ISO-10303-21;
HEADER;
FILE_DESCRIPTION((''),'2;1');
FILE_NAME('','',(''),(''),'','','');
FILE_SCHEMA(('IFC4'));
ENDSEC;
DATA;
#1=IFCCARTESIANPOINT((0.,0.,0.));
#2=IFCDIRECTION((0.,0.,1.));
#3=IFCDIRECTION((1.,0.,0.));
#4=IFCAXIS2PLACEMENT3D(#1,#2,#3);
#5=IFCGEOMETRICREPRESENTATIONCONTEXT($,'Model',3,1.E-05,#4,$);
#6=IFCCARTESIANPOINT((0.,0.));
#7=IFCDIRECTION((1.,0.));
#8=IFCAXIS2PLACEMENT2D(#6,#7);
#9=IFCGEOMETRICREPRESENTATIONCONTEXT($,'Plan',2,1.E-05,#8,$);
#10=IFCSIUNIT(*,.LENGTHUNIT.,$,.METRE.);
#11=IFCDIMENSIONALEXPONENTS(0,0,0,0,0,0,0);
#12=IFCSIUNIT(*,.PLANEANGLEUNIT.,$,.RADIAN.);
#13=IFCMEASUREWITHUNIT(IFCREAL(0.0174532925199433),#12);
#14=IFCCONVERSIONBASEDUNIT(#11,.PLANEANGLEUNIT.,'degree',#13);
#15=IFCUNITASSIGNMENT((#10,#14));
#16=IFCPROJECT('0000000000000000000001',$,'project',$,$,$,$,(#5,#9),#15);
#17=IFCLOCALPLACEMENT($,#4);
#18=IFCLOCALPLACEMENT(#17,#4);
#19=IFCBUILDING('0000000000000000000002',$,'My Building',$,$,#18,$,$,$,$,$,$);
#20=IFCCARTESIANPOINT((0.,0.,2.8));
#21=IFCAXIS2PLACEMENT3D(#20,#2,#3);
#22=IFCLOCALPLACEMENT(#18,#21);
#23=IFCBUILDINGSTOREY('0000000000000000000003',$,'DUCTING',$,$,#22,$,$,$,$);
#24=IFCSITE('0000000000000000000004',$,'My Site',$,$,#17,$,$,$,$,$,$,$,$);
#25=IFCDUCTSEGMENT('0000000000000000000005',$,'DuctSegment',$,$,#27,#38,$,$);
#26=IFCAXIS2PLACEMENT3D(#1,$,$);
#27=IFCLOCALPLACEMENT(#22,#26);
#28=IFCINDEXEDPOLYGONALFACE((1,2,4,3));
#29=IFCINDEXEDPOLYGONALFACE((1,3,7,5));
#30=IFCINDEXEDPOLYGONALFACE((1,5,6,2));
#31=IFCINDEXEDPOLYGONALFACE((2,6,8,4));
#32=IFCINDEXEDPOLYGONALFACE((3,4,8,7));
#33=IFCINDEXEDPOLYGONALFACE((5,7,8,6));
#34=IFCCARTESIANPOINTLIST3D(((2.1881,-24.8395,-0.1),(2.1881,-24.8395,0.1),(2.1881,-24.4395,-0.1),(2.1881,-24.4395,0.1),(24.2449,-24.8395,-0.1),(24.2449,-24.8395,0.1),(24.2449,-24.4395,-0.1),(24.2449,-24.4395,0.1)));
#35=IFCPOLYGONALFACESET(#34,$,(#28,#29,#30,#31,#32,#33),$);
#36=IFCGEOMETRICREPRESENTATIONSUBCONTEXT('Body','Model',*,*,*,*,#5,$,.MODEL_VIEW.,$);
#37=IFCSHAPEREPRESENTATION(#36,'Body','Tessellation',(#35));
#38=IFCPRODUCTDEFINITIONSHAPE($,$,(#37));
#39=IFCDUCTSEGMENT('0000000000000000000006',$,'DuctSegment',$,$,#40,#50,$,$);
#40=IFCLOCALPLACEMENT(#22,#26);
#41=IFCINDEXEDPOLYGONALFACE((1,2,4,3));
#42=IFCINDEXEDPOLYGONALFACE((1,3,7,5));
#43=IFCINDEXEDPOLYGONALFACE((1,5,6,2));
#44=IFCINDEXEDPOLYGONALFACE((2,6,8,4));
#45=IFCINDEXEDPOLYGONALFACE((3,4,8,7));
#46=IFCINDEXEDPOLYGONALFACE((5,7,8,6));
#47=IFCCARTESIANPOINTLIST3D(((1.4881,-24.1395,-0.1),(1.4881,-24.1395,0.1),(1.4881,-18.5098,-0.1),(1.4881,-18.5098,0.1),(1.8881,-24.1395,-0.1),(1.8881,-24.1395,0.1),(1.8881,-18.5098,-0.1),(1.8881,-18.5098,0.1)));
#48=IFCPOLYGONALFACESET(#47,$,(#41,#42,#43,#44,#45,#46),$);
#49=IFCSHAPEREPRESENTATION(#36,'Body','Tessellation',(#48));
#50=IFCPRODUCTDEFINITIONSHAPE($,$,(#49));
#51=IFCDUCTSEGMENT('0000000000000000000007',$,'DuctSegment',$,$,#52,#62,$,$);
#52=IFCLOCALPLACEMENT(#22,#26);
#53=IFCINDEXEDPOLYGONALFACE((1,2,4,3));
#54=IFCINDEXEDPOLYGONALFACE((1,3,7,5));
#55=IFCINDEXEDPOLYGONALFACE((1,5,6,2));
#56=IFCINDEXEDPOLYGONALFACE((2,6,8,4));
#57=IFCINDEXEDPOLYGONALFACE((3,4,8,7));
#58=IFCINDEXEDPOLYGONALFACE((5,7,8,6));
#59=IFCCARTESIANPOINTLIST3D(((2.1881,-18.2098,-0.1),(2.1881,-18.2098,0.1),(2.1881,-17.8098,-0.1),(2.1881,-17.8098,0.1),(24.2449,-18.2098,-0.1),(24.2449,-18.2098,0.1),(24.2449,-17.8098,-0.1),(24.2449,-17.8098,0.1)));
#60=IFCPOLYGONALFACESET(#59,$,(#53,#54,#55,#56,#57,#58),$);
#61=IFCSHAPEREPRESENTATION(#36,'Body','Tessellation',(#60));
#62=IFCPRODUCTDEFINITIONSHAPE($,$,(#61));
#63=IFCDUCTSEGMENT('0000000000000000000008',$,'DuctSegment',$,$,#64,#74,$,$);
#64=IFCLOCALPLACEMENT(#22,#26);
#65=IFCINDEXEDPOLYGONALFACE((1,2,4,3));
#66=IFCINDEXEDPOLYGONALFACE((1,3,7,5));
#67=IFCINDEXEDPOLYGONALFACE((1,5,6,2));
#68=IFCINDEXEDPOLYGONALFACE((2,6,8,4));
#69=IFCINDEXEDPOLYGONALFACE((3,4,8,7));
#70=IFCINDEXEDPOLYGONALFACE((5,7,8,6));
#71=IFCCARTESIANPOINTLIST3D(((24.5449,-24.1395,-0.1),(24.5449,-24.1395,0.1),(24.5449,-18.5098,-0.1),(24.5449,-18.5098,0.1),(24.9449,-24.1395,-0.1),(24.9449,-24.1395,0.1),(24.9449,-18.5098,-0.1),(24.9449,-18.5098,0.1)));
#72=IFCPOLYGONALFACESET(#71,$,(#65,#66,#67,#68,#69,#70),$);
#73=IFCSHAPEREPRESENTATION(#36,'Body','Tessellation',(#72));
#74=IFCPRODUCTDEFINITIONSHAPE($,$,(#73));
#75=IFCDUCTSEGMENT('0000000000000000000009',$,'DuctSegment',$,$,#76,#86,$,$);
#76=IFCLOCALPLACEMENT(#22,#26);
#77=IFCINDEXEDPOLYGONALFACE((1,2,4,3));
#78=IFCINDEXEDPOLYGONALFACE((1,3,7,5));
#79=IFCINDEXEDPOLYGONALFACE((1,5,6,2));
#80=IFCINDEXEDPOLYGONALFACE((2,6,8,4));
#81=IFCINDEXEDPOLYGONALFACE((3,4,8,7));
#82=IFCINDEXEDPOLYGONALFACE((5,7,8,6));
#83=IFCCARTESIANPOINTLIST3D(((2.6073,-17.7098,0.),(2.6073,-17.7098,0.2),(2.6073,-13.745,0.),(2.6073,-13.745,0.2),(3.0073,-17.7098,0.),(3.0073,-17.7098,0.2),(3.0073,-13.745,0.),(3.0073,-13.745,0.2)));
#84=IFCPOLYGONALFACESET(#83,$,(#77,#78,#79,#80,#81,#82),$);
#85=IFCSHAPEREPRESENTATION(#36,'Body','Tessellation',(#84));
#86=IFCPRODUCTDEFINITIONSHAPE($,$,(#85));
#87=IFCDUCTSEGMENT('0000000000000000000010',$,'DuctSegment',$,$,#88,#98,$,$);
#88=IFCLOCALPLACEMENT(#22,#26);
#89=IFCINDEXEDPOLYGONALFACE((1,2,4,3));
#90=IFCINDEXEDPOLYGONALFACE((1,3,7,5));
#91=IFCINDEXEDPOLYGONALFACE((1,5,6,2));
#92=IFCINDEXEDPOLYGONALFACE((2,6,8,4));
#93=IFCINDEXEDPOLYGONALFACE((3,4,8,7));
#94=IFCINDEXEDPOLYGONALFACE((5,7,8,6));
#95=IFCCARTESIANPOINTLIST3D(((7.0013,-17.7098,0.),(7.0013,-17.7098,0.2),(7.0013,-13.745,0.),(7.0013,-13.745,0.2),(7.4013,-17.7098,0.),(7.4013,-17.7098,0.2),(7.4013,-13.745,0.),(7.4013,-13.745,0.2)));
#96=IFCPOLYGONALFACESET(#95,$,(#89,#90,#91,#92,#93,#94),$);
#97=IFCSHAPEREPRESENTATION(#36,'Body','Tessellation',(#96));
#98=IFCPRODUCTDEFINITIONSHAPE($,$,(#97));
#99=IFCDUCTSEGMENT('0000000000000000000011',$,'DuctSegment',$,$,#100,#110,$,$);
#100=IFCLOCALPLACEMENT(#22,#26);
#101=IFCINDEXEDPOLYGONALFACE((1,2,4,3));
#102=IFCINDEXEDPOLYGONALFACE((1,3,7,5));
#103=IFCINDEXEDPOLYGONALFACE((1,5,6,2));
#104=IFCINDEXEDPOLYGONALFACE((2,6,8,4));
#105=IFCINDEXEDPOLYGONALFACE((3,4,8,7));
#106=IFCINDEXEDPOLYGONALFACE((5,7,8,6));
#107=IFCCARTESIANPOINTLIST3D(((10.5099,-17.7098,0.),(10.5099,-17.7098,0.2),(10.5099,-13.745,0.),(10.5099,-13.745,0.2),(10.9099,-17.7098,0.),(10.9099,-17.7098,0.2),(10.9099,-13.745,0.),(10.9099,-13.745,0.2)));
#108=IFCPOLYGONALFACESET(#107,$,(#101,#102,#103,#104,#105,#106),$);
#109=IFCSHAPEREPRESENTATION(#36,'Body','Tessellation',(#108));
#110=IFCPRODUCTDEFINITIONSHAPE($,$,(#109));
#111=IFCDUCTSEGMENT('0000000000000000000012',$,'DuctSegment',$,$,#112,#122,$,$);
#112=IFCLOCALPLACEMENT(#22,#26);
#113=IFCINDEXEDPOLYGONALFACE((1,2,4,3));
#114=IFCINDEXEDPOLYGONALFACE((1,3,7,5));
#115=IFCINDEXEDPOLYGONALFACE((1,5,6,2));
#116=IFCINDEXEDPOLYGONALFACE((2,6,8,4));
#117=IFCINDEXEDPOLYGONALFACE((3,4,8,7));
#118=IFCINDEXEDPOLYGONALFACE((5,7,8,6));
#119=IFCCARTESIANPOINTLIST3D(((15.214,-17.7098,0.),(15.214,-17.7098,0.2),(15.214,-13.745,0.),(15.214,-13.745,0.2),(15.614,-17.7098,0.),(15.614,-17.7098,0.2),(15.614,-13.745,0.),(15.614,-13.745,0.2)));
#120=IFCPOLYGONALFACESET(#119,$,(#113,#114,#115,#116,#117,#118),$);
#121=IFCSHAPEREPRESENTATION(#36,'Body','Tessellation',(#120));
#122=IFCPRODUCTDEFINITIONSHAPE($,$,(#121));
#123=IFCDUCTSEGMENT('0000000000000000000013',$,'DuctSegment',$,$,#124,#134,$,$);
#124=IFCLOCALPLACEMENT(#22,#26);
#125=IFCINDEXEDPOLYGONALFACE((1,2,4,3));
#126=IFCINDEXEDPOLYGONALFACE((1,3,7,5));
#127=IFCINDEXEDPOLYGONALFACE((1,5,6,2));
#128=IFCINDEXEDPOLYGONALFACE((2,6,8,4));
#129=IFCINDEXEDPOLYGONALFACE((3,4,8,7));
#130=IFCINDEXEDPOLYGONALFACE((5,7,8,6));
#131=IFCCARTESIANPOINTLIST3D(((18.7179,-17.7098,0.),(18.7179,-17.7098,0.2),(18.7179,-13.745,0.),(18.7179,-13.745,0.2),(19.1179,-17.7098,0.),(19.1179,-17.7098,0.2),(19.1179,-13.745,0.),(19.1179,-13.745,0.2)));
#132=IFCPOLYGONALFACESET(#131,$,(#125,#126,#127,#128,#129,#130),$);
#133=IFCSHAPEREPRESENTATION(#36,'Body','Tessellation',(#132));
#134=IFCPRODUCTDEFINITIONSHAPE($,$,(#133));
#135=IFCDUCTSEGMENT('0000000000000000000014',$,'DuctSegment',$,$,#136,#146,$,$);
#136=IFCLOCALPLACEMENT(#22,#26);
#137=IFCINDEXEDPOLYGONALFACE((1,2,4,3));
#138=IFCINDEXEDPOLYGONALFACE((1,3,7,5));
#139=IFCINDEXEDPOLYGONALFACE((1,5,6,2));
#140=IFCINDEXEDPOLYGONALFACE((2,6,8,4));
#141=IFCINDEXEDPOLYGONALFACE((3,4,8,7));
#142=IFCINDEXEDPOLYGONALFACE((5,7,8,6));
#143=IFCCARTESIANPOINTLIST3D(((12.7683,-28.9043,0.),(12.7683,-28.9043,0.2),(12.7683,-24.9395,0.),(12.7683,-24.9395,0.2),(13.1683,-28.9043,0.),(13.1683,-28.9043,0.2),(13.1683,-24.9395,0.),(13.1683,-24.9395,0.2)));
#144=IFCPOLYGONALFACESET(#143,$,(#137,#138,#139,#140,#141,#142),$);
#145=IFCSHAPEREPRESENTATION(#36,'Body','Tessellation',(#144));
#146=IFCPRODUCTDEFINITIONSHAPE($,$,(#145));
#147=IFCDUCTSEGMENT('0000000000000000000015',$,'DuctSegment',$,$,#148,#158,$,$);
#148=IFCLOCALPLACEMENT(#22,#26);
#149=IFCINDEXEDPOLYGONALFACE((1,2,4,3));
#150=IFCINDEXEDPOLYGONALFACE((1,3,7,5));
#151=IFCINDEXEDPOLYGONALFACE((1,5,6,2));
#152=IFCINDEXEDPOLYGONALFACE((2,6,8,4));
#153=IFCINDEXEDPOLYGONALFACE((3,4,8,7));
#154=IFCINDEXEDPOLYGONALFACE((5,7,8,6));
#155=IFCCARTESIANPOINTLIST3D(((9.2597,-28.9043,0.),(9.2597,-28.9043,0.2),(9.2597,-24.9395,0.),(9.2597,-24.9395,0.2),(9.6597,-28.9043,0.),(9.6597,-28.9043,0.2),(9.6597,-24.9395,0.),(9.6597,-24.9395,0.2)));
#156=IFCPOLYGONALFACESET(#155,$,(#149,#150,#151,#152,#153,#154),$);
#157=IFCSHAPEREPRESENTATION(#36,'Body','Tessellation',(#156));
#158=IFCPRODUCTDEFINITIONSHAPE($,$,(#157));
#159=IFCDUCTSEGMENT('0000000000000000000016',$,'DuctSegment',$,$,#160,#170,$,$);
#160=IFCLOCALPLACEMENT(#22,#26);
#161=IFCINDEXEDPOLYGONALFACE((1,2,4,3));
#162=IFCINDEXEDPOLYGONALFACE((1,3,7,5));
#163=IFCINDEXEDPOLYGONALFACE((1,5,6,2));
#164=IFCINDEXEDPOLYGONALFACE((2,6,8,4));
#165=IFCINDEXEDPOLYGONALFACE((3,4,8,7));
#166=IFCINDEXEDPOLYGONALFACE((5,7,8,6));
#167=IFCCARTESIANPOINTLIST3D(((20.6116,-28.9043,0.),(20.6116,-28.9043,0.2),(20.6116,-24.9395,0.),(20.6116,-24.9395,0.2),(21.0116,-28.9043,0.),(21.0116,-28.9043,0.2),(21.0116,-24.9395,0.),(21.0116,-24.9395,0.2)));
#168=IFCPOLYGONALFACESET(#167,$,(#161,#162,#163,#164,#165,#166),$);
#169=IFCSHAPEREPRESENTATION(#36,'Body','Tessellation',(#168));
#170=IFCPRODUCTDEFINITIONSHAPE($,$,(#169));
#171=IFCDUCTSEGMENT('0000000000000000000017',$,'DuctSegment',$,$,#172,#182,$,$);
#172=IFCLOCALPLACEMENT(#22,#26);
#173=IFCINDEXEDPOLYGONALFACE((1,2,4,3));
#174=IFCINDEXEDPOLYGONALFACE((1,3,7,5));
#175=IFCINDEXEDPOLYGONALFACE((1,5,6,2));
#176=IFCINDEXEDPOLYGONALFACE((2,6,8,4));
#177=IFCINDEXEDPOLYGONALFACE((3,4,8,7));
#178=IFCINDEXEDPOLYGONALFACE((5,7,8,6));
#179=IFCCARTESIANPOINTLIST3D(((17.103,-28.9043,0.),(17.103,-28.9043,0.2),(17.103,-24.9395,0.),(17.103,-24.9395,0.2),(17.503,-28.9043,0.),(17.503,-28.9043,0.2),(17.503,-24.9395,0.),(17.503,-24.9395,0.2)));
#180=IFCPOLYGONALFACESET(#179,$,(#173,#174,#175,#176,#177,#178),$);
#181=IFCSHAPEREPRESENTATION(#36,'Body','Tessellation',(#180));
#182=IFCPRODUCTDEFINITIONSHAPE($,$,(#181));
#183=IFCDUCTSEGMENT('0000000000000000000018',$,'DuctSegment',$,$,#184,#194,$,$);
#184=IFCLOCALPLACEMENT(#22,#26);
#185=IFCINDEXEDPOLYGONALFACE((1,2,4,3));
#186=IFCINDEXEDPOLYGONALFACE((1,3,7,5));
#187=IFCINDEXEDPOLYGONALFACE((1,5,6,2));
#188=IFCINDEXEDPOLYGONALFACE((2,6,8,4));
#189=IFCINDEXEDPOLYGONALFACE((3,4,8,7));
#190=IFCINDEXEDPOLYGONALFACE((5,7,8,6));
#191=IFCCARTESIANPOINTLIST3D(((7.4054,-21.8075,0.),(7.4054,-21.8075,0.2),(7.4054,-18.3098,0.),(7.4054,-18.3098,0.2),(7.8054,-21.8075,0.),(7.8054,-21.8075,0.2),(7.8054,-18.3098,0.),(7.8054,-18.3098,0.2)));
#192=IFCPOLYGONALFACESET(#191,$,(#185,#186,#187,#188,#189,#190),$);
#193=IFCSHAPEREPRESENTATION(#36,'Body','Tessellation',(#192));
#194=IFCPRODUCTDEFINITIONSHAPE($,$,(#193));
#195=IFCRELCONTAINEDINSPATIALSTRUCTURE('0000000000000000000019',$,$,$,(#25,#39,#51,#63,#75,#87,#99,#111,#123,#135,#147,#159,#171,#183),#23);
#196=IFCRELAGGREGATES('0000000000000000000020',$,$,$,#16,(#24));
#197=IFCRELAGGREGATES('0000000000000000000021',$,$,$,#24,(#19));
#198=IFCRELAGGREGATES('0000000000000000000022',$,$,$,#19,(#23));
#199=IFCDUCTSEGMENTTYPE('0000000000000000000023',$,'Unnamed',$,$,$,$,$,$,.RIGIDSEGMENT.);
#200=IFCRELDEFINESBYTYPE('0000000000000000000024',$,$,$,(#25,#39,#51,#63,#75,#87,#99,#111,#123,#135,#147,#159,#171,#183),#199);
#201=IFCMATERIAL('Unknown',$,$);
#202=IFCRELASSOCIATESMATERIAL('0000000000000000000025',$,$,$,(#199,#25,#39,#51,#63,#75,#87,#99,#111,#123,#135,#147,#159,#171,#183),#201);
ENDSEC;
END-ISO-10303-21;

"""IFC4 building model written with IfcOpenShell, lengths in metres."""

from ifc_helpers import new_model, entity, si_unit, converted_unit, frame, origin_with_axes, origin_2d_with_axis, place, context, subcontext, project, spatial, rectangle, extrude, material, material_profile, profile_set, profile_usage, type_object, element, save


model = new_model("IFC4")

# Units and contexts
model_context = context("Model", 3, precision=1e-05, world=origin_with_axes())
plan_context = context("Plan", 2, precision=1e-05, world=origin_2d_with_axis())
body_context = subcontext(model_context, "Body", "Model", "MODEL_VIEW")
ifc_project = project(units=[si_unit("LENGTHUNIT", "METRE"), converted_unit("PLANEANGLEUNIT", "degree", entity("IfcReal", 0.0174532925199433), si_unit("PLANEANGLEUNIT", "RADIAN"), dimensions=[0, 0, 0, 0, 0, 0, 0])], contexts=[model_context, plan_context])

# Site, building, storey
site_placement = place(None, origin_with_axes())
site = spatial("IfcSite", under=ifc_project, at=site_placement, Name="My Site")
building_placement = place(site_placement, origin_with_axes())
building = spatial("IfcBuilding", under=site, at=building_placement, Name="My Building")
storey_placement = place(building_placement, frame((0.0, 0.0, 2.8), z_axis=(0.0, 0.0, 1.0), x_axis=(1.0, 0.0, 0.0)))
storey = spatial("IfcBuildingStorey", under=building, at=storey_placement, Name="DUCTING")

# Duct segments
ifc_material = material(Name="Unknown")
ifc_material_profile_1 = material_profile(ifc_material, rectangle(XDim=0.4, YDim=0.2))
ifc_profile_set_1 = profile_set([ifc_material_profile_1])
ifc_profile_usage_1 = profile_usage(ifc_profile_set_1, cardinal=5)
duct_segment_type = type_object("IfcDuctSegmentType", Name="Unnamed", PredefinedType="RIGIDSEGMENT", material=ifc_profile_set_1)
duct_segment_1_placement = place(storey_placement, frame((2.1881, -24.6395, 0.0), z_axis=(1.0, 0.0, 0.0), x_axis=(0.0, 1.0, 0.0)))
element("IfcDuctSegment", 1, at=duct_segment_1_placement, inside=storey, type_object=duct_segment_type, material=ifc_profile_usage_1, Name="DuctSegment", context=body_context, shape_type="SweptSolid", body=[
    extrude(rectangle(XDim=0.4, YDim=0.2), origin_with_axes(), (0.0, 0.0, 1.0), 22.0569),
])
ifc_profile_usage_2 = profile_usage(ifc_profile_set_1, cardinal=5)
duct_segment_2_placement = place(storey_placement, frame((1.6881, -24.1395, 0.0), z_axis=(0.0, 1.0, 0.0), x_axis=(-1.0, 0.0, 0.0)))
element("IfcDuctSegment", 2, at=duct_segment_2_placement, inside=storey, type_object=duct_segment_type, material=ifc_profile_usage_2, Name="DuctSegment", context=body_context, shape_type="SweptSolid", body=[
    extrude(rectangle(XDim=0.4, YDim=0.2), origin_with_axes(), (0.0, 0.0, 1.0), 5.6297),
])
ifc_profile_usage_3 = profile_usage(ifc_profile_set_1, cardinal=5)
duct_segment_3_placement = place(storey_placement, frame((24.2449, -18.0098, 0.0), z_axis=(-1.0, 0.0, 0.0), x_axis=(0.0, 1.0, 0.0)))
element("IfcDuctSegment", 3, at=duct_segment_3_placement, inside=storey, type_object=duct_segment_type, material=ifc_profile_usage_3, Name="DuctSegment", context=body_context, shape_type="SweptSolid", body=[
    extrude(rectangle(XDim=0.4, YDim=0.2), origin_with_axes(), (0.0, 0.0, 1.0), 22.0569),
])
ifc_profile_usage_4 = profile_usage(ifc_profile_set_1, cardinal=5)
duct_segment_4_placement = place(storey_placement, frame((24.7449, -18.5098, 0.0), z_axis=(0.0, -1.0, 0.0), x_axis=(1.0, 0.0, 0.0)))
element("IfcDuctSegment", 4, at=duct_segment_4_placement, inside=storey, type_object=duct_segment_type, material=ifc_profile_usage_4, Name="DuctSegment", context=body_context, shape_type="SweptSolid", body=[
    extrude(rectangle(XDim=0.4, YDim=0.2), origin_with_axes(), (0.0, 0.0, 1.0), 5.6297),
])
ifc_profile_usage_5 = profile_usage(ifc_profile_set_1, cardinal=5)
duct_segment_5_placement = place(storey_placement, frame((2.8073, -17.7098, 0.1), z_axis=(0.0, 1.0, 0.0), x_axis=(-1.0, 0.0, 0.0)))
element("IfcDuctSegment", 5, at=duct_segment_5_placement, inside=storey, type_object=duct_segment_type, material=ifc_profile_usage_5, Name="DuctSegment", context=body_context, shape_type="SweptSolid", body=[
    extrude(rectangle(XDim=0.4, YDim=0.2), origin_with_axes(), (0.0, 0.0, 1.0), 3.9648),
])
ifc_profile_usage_6 = profile_usage(ifc_profile_set_1, cardinal=5)
duct_segment_6_placement = place(storey_placement, frame((7.2013, -17.7098, 0.1), z_axis=(0.0, 1.0, 0.0), x_axis=(-1.0, 0.0, 0.0)))
element("IfcDuctSegment", 6, at=duct_segment_6_placement, inside=storey, type_object=duct_segment_type, material=ifc_profile_usage_6, Name="DuctSegment", context=body_context, shape_type="SweptSolid", body=[
    extrude(rectangle(XDim=0.4, YDim=0.2), origin_with_axes(), (0.0, 0.0, 1.0), 3.9648),
])
ifc_profile_usage_7 = profile_usage(ifc_profile_set_1, cardinal=5)
duct_segment_7_placement = place(storey_placement, frame((10.7099, -17.7098, 0.1), z_axis=(0.0, 1.0, 0.0), x_axis=(-1.0, 0.0, 0.0)))
element("IfcDuctSegment", 7, at=duct_segment_7_placement, inside=storey, type_object=duct_segment_type, material=ifc_profile_usage_7, Name="DuctSegment", context=body_context, shape_type="SweptSolid", body=[
    extrude(rectangle(XDim=0.4, YDim=0.2), origin_with_axes(), (0.0, 0.0, 1.0), 3.9648),
])
ifc_profile_usage_8 = profile_usage(ifc_profile_set_1, cardinal=5)
duct_segment_8_placement = place(storey_placement, frame((15.414, -17.7098, 0.1), z_axis=(0.0, 1.0, 0.0), x_axis=(-1.0, 0.0, 0.0)))
element("IfcDuctSegment", 8, at=duct_segment_8_placement, inside=storey, type_object=duct_segment_type, material=ifc_profile_usage_8, Name="DuctSegment", context=body_context, shape_type="SweptSolid", body=[
    extrude(rectangle(XDim=0.4, YDim=0.2), origin_with_axes(), (0.0, 0.0, 1.0), 3.9648),
])
ifc_profile_usage_9 = profile_usage(ifc_profile_set_1, cardinal=5)
duct_segment_9_placement = place(storey_placement, frame((18.9179, -17.7098, 0.1), z_axis=(0.0, 1.0, 0.0), x_axis=(-1.0, 0.0, 0.0)))
element("IfcDuctSegment", 9, at=duct_segment_9_placement, inside=storey, type_object=duct_segment_type, material=ifc_profile_usage_9, Name="DuctSegment", context=body_context, shape_type="SweptSolid", body=[
    extrude(rectangle(XDim=0.4, YDim=0.2), origin_with_axes(), (0.0, 0.0, 1.0), 3.9648),
])
ifc_profile_usage_10 = profile_usage(ifc_profile_set_1, cardinal=5)
duct_segment_10_placement = place(storey_placement, frame((12.9683, -24.9395, 0.1), z_axis=(0.0, -1.0, 0.0), x_axis=(1.0, 0.0, 0.0)))
element("IfcDuctSegment", 10, at=duct_segment_10_placement, inside=storey, type_object=duct_segment_type, material=ifc_profile_usage_10, Name="DuctSegment", context=body_context, shape_type="SweptSolid", body=[
    extrude(rectangle(XDim=0.4, YDim=0.2), origin_with_axes(), (0.0, 0.0, 1.0), 3.9648),
])
ifc_profile_usage_11 = profile_usage(ifc_profile_set_1, cardinal=5)
duct_segment_11_placement = place(storey_placement, frame((9.4597, -24.9395, 0.1), z_axis=(0.0, -1.0, 0.0), x_axis=(1.0, 0.0, 0.0)))
element("IfcDuctSegment", 11, at=duct_segment_11_placement, inside=storey, type_object=duct_segment_type, material=ifc_profile_usage_11, Name="DuctSegment", context=body_context, shape_type="SweptSolid", body=[
    extrude(rectangle(XDim=0.4, YDim=0.2), origin_with_axes(), (0.0, 0.0, 1.0), 3.9648),
])
ifc_profile_usage_12 = profile_usage(ifc_profile_set_1, cardinal=5)
duct_segment_12_placement = place(storey_placement, frame((20.8116, -24.9395, 0.1), z_axis=(0.0, -1.0, 0.0), x_axis=(1.0, 0.0, 0.0)))
element("IfcDuctSegment", 12, at=duct_segment_12_placement, inside=storey, type_object=duct_segment_type, material=ifc_profile_usage_12, Name="DuctSegment", context=body_context, shape_type="SweptSolid", body=[
    extrude(rectangle(XDim=0.4, YDim=0.2), origin_with_axes(), (0.0, 0.0, 1.0), 3.9648),
])
ifc_profile_usage_13 = profile_usage(ifc_profile_set_1, cardinal=5)
duct_segment_13_placement = place(storey_placement, frame((17.303, -24.9395, 0.1), z_axis=(0.0, -1.0, 0.0), x_axis=(1.0, 0.0, 0.0)))
element("IfcDuctSegment", 13, at=duct_segment_13_placement, inside=storey, type_object=duct_segment_type, material=ifc_profile_usage_13, Name="DuctSegment", context=body_context, shape_type="SweptSolid", body=[
    extrude(rectangle(XDim=0.4, YDim=0.2), origin_with_axes(), (0.0, 0.0, 1.0), 3.9648),
])
ifc_profile_usage_14 = profile_usage(ifc_profile_set_1, cardinal=5)
duct_segment_14_placement = place(storey_placement, frame((7.6054, -18.3098, 0.1), z_axis=(0.0, -1.0, 0.0), x_axis=(1.0, 0.0, 0.0)))
element("IfcDuctSegment", 14, at=duct_segment_14_placement, inside=storey, type_object=duct_segment_type, material=ifc_profile_usage_14, Name="DuctSegment", context=body_context, shape_type="SweptSolid", body=[
    extrude(rectangle(XDim=0.4, YDim=0.2), origin_with_axes(), (0.0, 0.0, 1.0), 3.4977),
])

save(model, "model.ifc")
